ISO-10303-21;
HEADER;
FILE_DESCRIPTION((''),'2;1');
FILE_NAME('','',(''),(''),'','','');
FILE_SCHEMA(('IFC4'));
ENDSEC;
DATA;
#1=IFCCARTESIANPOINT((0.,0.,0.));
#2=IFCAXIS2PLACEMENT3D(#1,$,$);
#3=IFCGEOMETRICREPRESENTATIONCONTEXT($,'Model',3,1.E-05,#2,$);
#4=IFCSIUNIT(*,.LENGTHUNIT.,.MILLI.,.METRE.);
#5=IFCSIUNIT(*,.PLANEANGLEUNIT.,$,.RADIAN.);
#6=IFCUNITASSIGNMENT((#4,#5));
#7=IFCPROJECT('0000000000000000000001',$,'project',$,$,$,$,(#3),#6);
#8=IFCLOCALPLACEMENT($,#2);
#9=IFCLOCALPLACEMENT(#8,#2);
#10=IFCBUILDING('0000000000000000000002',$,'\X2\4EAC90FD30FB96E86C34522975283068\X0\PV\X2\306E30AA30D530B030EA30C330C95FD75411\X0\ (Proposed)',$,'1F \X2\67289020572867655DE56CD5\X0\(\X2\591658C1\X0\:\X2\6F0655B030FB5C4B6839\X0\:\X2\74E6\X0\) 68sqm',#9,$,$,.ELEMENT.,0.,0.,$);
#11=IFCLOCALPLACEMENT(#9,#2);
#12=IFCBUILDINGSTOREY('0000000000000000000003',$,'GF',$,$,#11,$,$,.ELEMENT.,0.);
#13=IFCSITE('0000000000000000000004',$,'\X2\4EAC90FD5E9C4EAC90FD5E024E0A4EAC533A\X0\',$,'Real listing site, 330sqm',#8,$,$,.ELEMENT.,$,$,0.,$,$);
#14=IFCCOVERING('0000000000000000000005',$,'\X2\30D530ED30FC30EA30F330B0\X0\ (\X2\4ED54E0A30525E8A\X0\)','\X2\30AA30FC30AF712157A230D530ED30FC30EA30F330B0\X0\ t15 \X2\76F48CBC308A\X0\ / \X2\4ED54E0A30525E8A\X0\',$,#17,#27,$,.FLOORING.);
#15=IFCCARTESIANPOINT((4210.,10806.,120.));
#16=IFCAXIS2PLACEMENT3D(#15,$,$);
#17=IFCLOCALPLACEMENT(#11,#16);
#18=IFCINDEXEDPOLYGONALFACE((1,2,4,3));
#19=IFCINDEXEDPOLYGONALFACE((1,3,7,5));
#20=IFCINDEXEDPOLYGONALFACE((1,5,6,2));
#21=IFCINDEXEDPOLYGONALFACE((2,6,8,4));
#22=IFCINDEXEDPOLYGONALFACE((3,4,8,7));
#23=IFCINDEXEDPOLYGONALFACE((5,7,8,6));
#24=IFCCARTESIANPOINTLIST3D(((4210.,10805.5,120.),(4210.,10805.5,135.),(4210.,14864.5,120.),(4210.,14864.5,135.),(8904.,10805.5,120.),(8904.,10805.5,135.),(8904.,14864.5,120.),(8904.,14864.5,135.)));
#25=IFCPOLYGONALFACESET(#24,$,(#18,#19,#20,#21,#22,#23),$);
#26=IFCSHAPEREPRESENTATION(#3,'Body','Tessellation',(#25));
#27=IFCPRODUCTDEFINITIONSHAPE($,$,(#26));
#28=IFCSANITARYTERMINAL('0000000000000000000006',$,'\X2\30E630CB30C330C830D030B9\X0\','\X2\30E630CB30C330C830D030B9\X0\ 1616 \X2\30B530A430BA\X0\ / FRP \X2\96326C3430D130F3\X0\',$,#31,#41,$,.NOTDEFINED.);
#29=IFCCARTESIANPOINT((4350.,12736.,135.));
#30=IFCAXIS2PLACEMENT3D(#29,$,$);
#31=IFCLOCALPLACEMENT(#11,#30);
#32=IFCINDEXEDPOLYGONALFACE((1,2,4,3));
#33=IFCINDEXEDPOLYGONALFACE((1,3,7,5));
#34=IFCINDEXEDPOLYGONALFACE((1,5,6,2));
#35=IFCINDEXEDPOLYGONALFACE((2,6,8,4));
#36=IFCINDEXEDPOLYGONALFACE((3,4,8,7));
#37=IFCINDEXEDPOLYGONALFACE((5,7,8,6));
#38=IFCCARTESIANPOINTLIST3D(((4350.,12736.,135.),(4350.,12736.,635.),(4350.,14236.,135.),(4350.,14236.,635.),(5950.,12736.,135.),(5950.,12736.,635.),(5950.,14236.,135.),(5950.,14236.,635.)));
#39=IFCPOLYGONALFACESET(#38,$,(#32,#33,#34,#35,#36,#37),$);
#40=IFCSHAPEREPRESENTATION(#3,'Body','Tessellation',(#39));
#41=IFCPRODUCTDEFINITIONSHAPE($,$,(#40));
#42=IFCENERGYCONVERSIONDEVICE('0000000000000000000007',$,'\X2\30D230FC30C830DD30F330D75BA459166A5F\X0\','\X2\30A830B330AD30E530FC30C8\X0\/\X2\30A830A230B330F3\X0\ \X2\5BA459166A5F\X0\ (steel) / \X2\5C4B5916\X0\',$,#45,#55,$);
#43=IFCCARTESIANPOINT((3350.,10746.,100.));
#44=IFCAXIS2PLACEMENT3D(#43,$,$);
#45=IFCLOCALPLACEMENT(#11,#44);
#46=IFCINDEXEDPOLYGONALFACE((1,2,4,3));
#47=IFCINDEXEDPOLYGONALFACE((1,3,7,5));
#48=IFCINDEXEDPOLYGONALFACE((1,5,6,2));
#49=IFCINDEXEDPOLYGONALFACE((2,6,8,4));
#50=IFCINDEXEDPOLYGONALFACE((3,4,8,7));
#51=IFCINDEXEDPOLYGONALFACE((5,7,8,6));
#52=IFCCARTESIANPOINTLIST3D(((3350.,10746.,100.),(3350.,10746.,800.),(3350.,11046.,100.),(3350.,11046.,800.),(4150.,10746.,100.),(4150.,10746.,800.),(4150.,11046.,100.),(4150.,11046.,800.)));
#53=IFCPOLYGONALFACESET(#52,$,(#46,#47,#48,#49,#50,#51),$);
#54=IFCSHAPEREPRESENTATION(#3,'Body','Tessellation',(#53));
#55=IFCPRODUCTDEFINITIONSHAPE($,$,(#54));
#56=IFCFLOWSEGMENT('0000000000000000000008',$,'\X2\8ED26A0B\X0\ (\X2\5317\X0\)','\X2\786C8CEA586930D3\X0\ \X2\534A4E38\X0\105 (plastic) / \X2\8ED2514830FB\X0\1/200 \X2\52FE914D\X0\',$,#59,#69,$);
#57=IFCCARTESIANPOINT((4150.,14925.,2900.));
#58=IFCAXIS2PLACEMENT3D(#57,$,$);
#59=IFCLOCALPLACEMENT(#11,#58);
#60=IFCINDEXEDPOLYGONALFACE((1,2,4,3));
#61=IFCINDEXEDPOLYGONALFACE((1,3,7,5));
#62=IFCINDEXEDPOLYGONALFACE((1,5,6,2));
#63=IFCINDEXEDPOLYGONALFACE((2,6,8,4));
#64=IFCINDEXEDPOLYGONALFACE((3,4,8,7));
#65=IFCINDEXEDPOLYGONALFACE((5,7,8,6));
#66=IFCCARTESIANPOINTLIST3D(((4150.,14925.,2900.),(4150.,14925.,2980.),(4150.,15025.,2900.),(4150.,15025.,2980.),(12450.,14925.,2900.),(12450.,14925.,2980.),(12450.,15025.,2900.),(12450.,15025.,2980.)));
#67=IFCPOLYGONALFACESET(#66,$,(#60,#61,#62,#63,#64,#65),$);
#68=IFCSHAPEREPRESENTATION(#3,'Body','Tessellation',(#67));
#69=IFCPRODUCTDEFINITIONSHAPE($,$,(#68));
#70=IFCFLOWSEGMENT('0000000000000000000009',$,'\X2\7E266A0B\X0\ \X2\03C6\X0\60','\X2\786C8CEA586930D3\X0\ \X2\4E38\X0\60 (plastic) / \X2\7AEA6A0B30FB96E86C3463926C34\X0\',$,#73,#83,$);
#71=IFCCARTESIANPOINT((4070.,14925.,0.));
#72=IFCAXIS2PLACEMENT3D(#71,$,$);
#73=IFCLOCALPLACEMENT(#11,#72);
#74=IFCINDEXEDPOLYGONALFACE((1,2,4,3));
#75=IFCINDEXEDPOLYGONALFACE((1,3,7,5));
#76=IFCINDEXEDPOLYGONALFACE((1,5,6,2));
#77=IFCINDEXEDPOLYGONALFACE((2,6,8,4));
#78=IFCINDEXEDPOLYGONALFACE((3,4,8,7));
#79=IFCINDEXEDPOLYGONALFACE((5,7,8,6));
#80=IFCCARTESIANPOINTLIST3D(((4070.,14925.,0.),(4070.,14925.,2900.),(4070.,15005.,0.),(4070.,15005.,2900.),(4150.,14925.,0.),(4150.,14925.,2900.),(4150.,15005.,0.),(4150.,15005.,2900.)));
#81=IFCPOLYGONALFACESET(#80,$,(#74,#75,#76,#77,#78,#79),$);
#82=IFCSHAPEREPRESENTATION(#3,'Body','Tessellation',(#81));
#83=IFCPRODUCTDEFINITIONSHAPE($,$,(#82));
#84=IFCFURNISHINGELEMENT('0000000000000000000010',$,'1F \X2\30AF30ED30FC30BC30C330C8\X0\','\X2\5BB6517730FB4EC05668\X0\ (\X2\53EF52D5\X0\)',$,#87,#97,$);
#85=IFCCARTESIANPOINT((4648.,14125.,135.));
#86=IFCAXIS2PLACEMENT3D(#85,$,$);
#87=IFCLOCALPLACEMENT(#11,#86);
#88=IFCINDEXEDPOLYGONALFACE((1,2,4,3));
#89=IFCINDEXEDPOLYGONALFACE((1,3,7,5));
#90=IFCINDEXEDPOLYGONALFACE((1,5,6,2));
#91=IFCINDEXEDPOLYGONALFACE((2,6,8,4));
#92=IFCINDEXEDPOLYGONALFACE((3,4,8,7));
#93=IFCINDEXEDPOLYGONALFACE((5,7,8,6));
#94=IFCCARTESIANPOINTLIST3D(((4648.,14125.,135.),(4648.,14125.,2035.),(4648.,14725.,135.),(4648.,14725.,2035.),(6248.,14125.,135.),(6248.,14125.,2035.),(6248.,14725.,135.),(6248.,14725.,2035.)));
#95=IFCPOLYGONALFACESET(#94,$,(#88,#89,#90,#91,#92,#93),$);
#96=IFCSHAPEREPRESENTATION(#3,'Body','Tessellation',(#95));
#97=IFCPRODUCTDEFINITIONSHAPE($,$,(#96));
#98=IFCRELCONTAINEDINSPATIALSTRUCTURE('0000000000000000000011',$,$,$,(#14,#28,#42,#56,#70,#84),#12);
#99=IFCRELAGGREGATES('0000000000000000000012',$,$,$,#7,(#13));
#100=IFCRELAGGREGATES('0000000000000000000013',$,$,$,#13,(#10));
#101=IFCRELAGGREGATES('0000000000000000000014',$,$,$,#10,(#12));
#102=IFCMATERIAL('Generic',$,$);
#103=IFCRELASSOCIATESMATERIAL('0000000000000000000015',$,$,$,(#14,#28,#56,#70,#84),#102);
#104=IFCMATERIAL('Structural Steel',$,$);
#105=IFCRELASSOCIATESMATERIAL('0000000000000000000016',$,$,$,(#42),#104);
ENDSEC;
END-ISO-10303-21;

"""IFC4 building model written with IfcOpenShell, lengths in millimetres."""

from ifc_helpers import new_model, si_unit, frame, frame_2d, origin, place, context, project, spatial, rectangle, extrude, material, element, save


model = new_model("IFC4")

# Units and contexts
model_context = context("Model", 3, precision=1e-05, world=origin())
ifc_project = project(units=[si_unit("LENGTHUNIT", "METRE", prefix="MILLI"), si_unit("PLANEANGLEUNIT", "RADIAN")], contexts=[model_context])

# Site, building, storey
site_placement = place(None, origin())
site = spatial("IfcSite", under=ifc_project, at=site_placement, Name="京都府京都市上京区", ObjectType="Real listing site, 330sqm", CompositionType="ELEMENT", RefElevation=0.0)
building_placement = place(site_placement, origin())
building = spatial("IfcBuilding", under=site, at=building_placement, Name="京都・雨水利用とPVのオフグリッド志向 (Proposed)", ObjectType="1F 木造在来工法(外壁:漆喰・屋根:瓦) 68sqm", CompositionType="ELEMENT", ElevationOfRefHeight=0.0, ElevationOfTerrain=0.0)
storey_placement = place(building_placement, origin())
storey = spatial("IfcBuildingStorey", under=building, at=storey_placement, Name="GF", CompositionType="ELEMENT", Elevation=0.0)

# Shared definitions
ifc_material_1 = material(Name="Structural Steel")

# Covering
ifc_material_2 = material(Name="Generic")
covering_placement = place(storey_placement, frame((4210.0, 10806.0, 120.0)))
element("IfcCovering", 1, at=covering_placement, inside=storey, material=ifc_material_2, Name="フローリング (仕上げ床)", Description="オーク無垢フローリング t15 直貼り / 仕上げ床", PredefinedType="FLOORING", context=model_context, shape_type="SweptSolid", body=[
    extrude(rectangle(XDim=4694.0, YDim=4059.0, at=frame_2d((2347.0, 2029.0))), frame((4210.0, 10806.0, 120.0)), (0.0, 0.0, 1.0), 15.0),
])

# Sanitary terminal
sanitary_terminal_placement = place(storey_placement, frame((4350.0, 12736.0, 135.0)))
element("IfcSanitaryTerminal", 2, at=sanitary_terminal_placement, inside=storey, material=ifc_material_2, Name="ユニットバス", Description="ユニットバス 1616 サイズ / FRP 防水パン", PredefinedType="NOTDEFINED", context=model_context, shape_type="SweptSolid", body=[
    extrude(rectangle(XDim=1600.0, YDim=1500.0, at=frame_2d((800.0, 750.0))), frame((4350.0, 12736.0, 135.0)), (0.0, 0.0, 1.0), 500.0),
])

# Energy conversion device
energy_conversion_device_placement = place(storey_placement, frame((3350.0, 10746.0, 100.0)))
element("IfcEnergyConversionDevice", 3, at=energy_conversion_device_placement, inside=storey, material=ifc_material_1, Name="ヒートポンプ室外機", Description="エコキュート/エアコン 室外機 (steel) / 屋外", context=model_context, shape_type="SweptSolid", body=[
    extrude(rectangle(XDim=800.0, YDim=300.0, at=frame_2d((400.0, 150.0))), frame((3350.0, 10746.0, 100.0)), (0.0, 0.0, 1.0), 700.0),
])

# Flow segments
flow_segment_1_placement = place(storey_placement, frame((4150.0, 14925.0, 2900.0)))
element("IfcFlowSegment", 4, at=flow_segment_1_placement, inside=storey, material=ifc_material_2, Name="軒樋 (北)", Description="硬質塩ビ 半丸105 (plastic) / 軒先・1/200 勾配", context=model_context, shape_type="SweptSolid", body=[
    extrude(rectangle(XDim=8300.0, YDim=100.0, at=frame_2d((4150.0, 50.0))), frame((4150.0, 14925.0, 2900.0)), (0.0, 0.0, 1.0), 80.0),
])
flow_segment_2_placement = place(storey_placement, frame((4070.0, 14925.0, 0.0)))
element("IfcFlowSegment", 5, at=flow_segment_2_placement, inside=storey, material=ifc_material_2, Name="縦樋 φ60", Description="硬質塩ビ 丸60 (plastic) / 竪樋・雨水排水", context=model_context, shape_type="SweptSolid", body=[
    extrude(rectangle(XDim=80.0, YDim=80.0, at=frame_2d((40.0, 40.0))), frame((4070.0, 14925.0, 0.0)), (0.0, 0.0, 1.0), 2900.0),
])

# Furnishing element
furnishing_placement = place(storey_placement, frame((4648.0, 14125.0, 135.0)))
element("IfcFurnishingElement", 6, at=furnishing_placement, inside=storey, material=ifc_material_2, Name="1F クローゼット", Description="家具・什器 (可動)", context=model_context, shape_type="SweptSolid", body=[
    extrude(rectangle(XDim=1600.0, YDim=600.0, at=frame_2d((800.0, 300.0))), frame((4648.0, 14125.0, 135.0)), (0.0, 0.0, 1.0), 1900.0),
])

save(model, "model.ifc")
